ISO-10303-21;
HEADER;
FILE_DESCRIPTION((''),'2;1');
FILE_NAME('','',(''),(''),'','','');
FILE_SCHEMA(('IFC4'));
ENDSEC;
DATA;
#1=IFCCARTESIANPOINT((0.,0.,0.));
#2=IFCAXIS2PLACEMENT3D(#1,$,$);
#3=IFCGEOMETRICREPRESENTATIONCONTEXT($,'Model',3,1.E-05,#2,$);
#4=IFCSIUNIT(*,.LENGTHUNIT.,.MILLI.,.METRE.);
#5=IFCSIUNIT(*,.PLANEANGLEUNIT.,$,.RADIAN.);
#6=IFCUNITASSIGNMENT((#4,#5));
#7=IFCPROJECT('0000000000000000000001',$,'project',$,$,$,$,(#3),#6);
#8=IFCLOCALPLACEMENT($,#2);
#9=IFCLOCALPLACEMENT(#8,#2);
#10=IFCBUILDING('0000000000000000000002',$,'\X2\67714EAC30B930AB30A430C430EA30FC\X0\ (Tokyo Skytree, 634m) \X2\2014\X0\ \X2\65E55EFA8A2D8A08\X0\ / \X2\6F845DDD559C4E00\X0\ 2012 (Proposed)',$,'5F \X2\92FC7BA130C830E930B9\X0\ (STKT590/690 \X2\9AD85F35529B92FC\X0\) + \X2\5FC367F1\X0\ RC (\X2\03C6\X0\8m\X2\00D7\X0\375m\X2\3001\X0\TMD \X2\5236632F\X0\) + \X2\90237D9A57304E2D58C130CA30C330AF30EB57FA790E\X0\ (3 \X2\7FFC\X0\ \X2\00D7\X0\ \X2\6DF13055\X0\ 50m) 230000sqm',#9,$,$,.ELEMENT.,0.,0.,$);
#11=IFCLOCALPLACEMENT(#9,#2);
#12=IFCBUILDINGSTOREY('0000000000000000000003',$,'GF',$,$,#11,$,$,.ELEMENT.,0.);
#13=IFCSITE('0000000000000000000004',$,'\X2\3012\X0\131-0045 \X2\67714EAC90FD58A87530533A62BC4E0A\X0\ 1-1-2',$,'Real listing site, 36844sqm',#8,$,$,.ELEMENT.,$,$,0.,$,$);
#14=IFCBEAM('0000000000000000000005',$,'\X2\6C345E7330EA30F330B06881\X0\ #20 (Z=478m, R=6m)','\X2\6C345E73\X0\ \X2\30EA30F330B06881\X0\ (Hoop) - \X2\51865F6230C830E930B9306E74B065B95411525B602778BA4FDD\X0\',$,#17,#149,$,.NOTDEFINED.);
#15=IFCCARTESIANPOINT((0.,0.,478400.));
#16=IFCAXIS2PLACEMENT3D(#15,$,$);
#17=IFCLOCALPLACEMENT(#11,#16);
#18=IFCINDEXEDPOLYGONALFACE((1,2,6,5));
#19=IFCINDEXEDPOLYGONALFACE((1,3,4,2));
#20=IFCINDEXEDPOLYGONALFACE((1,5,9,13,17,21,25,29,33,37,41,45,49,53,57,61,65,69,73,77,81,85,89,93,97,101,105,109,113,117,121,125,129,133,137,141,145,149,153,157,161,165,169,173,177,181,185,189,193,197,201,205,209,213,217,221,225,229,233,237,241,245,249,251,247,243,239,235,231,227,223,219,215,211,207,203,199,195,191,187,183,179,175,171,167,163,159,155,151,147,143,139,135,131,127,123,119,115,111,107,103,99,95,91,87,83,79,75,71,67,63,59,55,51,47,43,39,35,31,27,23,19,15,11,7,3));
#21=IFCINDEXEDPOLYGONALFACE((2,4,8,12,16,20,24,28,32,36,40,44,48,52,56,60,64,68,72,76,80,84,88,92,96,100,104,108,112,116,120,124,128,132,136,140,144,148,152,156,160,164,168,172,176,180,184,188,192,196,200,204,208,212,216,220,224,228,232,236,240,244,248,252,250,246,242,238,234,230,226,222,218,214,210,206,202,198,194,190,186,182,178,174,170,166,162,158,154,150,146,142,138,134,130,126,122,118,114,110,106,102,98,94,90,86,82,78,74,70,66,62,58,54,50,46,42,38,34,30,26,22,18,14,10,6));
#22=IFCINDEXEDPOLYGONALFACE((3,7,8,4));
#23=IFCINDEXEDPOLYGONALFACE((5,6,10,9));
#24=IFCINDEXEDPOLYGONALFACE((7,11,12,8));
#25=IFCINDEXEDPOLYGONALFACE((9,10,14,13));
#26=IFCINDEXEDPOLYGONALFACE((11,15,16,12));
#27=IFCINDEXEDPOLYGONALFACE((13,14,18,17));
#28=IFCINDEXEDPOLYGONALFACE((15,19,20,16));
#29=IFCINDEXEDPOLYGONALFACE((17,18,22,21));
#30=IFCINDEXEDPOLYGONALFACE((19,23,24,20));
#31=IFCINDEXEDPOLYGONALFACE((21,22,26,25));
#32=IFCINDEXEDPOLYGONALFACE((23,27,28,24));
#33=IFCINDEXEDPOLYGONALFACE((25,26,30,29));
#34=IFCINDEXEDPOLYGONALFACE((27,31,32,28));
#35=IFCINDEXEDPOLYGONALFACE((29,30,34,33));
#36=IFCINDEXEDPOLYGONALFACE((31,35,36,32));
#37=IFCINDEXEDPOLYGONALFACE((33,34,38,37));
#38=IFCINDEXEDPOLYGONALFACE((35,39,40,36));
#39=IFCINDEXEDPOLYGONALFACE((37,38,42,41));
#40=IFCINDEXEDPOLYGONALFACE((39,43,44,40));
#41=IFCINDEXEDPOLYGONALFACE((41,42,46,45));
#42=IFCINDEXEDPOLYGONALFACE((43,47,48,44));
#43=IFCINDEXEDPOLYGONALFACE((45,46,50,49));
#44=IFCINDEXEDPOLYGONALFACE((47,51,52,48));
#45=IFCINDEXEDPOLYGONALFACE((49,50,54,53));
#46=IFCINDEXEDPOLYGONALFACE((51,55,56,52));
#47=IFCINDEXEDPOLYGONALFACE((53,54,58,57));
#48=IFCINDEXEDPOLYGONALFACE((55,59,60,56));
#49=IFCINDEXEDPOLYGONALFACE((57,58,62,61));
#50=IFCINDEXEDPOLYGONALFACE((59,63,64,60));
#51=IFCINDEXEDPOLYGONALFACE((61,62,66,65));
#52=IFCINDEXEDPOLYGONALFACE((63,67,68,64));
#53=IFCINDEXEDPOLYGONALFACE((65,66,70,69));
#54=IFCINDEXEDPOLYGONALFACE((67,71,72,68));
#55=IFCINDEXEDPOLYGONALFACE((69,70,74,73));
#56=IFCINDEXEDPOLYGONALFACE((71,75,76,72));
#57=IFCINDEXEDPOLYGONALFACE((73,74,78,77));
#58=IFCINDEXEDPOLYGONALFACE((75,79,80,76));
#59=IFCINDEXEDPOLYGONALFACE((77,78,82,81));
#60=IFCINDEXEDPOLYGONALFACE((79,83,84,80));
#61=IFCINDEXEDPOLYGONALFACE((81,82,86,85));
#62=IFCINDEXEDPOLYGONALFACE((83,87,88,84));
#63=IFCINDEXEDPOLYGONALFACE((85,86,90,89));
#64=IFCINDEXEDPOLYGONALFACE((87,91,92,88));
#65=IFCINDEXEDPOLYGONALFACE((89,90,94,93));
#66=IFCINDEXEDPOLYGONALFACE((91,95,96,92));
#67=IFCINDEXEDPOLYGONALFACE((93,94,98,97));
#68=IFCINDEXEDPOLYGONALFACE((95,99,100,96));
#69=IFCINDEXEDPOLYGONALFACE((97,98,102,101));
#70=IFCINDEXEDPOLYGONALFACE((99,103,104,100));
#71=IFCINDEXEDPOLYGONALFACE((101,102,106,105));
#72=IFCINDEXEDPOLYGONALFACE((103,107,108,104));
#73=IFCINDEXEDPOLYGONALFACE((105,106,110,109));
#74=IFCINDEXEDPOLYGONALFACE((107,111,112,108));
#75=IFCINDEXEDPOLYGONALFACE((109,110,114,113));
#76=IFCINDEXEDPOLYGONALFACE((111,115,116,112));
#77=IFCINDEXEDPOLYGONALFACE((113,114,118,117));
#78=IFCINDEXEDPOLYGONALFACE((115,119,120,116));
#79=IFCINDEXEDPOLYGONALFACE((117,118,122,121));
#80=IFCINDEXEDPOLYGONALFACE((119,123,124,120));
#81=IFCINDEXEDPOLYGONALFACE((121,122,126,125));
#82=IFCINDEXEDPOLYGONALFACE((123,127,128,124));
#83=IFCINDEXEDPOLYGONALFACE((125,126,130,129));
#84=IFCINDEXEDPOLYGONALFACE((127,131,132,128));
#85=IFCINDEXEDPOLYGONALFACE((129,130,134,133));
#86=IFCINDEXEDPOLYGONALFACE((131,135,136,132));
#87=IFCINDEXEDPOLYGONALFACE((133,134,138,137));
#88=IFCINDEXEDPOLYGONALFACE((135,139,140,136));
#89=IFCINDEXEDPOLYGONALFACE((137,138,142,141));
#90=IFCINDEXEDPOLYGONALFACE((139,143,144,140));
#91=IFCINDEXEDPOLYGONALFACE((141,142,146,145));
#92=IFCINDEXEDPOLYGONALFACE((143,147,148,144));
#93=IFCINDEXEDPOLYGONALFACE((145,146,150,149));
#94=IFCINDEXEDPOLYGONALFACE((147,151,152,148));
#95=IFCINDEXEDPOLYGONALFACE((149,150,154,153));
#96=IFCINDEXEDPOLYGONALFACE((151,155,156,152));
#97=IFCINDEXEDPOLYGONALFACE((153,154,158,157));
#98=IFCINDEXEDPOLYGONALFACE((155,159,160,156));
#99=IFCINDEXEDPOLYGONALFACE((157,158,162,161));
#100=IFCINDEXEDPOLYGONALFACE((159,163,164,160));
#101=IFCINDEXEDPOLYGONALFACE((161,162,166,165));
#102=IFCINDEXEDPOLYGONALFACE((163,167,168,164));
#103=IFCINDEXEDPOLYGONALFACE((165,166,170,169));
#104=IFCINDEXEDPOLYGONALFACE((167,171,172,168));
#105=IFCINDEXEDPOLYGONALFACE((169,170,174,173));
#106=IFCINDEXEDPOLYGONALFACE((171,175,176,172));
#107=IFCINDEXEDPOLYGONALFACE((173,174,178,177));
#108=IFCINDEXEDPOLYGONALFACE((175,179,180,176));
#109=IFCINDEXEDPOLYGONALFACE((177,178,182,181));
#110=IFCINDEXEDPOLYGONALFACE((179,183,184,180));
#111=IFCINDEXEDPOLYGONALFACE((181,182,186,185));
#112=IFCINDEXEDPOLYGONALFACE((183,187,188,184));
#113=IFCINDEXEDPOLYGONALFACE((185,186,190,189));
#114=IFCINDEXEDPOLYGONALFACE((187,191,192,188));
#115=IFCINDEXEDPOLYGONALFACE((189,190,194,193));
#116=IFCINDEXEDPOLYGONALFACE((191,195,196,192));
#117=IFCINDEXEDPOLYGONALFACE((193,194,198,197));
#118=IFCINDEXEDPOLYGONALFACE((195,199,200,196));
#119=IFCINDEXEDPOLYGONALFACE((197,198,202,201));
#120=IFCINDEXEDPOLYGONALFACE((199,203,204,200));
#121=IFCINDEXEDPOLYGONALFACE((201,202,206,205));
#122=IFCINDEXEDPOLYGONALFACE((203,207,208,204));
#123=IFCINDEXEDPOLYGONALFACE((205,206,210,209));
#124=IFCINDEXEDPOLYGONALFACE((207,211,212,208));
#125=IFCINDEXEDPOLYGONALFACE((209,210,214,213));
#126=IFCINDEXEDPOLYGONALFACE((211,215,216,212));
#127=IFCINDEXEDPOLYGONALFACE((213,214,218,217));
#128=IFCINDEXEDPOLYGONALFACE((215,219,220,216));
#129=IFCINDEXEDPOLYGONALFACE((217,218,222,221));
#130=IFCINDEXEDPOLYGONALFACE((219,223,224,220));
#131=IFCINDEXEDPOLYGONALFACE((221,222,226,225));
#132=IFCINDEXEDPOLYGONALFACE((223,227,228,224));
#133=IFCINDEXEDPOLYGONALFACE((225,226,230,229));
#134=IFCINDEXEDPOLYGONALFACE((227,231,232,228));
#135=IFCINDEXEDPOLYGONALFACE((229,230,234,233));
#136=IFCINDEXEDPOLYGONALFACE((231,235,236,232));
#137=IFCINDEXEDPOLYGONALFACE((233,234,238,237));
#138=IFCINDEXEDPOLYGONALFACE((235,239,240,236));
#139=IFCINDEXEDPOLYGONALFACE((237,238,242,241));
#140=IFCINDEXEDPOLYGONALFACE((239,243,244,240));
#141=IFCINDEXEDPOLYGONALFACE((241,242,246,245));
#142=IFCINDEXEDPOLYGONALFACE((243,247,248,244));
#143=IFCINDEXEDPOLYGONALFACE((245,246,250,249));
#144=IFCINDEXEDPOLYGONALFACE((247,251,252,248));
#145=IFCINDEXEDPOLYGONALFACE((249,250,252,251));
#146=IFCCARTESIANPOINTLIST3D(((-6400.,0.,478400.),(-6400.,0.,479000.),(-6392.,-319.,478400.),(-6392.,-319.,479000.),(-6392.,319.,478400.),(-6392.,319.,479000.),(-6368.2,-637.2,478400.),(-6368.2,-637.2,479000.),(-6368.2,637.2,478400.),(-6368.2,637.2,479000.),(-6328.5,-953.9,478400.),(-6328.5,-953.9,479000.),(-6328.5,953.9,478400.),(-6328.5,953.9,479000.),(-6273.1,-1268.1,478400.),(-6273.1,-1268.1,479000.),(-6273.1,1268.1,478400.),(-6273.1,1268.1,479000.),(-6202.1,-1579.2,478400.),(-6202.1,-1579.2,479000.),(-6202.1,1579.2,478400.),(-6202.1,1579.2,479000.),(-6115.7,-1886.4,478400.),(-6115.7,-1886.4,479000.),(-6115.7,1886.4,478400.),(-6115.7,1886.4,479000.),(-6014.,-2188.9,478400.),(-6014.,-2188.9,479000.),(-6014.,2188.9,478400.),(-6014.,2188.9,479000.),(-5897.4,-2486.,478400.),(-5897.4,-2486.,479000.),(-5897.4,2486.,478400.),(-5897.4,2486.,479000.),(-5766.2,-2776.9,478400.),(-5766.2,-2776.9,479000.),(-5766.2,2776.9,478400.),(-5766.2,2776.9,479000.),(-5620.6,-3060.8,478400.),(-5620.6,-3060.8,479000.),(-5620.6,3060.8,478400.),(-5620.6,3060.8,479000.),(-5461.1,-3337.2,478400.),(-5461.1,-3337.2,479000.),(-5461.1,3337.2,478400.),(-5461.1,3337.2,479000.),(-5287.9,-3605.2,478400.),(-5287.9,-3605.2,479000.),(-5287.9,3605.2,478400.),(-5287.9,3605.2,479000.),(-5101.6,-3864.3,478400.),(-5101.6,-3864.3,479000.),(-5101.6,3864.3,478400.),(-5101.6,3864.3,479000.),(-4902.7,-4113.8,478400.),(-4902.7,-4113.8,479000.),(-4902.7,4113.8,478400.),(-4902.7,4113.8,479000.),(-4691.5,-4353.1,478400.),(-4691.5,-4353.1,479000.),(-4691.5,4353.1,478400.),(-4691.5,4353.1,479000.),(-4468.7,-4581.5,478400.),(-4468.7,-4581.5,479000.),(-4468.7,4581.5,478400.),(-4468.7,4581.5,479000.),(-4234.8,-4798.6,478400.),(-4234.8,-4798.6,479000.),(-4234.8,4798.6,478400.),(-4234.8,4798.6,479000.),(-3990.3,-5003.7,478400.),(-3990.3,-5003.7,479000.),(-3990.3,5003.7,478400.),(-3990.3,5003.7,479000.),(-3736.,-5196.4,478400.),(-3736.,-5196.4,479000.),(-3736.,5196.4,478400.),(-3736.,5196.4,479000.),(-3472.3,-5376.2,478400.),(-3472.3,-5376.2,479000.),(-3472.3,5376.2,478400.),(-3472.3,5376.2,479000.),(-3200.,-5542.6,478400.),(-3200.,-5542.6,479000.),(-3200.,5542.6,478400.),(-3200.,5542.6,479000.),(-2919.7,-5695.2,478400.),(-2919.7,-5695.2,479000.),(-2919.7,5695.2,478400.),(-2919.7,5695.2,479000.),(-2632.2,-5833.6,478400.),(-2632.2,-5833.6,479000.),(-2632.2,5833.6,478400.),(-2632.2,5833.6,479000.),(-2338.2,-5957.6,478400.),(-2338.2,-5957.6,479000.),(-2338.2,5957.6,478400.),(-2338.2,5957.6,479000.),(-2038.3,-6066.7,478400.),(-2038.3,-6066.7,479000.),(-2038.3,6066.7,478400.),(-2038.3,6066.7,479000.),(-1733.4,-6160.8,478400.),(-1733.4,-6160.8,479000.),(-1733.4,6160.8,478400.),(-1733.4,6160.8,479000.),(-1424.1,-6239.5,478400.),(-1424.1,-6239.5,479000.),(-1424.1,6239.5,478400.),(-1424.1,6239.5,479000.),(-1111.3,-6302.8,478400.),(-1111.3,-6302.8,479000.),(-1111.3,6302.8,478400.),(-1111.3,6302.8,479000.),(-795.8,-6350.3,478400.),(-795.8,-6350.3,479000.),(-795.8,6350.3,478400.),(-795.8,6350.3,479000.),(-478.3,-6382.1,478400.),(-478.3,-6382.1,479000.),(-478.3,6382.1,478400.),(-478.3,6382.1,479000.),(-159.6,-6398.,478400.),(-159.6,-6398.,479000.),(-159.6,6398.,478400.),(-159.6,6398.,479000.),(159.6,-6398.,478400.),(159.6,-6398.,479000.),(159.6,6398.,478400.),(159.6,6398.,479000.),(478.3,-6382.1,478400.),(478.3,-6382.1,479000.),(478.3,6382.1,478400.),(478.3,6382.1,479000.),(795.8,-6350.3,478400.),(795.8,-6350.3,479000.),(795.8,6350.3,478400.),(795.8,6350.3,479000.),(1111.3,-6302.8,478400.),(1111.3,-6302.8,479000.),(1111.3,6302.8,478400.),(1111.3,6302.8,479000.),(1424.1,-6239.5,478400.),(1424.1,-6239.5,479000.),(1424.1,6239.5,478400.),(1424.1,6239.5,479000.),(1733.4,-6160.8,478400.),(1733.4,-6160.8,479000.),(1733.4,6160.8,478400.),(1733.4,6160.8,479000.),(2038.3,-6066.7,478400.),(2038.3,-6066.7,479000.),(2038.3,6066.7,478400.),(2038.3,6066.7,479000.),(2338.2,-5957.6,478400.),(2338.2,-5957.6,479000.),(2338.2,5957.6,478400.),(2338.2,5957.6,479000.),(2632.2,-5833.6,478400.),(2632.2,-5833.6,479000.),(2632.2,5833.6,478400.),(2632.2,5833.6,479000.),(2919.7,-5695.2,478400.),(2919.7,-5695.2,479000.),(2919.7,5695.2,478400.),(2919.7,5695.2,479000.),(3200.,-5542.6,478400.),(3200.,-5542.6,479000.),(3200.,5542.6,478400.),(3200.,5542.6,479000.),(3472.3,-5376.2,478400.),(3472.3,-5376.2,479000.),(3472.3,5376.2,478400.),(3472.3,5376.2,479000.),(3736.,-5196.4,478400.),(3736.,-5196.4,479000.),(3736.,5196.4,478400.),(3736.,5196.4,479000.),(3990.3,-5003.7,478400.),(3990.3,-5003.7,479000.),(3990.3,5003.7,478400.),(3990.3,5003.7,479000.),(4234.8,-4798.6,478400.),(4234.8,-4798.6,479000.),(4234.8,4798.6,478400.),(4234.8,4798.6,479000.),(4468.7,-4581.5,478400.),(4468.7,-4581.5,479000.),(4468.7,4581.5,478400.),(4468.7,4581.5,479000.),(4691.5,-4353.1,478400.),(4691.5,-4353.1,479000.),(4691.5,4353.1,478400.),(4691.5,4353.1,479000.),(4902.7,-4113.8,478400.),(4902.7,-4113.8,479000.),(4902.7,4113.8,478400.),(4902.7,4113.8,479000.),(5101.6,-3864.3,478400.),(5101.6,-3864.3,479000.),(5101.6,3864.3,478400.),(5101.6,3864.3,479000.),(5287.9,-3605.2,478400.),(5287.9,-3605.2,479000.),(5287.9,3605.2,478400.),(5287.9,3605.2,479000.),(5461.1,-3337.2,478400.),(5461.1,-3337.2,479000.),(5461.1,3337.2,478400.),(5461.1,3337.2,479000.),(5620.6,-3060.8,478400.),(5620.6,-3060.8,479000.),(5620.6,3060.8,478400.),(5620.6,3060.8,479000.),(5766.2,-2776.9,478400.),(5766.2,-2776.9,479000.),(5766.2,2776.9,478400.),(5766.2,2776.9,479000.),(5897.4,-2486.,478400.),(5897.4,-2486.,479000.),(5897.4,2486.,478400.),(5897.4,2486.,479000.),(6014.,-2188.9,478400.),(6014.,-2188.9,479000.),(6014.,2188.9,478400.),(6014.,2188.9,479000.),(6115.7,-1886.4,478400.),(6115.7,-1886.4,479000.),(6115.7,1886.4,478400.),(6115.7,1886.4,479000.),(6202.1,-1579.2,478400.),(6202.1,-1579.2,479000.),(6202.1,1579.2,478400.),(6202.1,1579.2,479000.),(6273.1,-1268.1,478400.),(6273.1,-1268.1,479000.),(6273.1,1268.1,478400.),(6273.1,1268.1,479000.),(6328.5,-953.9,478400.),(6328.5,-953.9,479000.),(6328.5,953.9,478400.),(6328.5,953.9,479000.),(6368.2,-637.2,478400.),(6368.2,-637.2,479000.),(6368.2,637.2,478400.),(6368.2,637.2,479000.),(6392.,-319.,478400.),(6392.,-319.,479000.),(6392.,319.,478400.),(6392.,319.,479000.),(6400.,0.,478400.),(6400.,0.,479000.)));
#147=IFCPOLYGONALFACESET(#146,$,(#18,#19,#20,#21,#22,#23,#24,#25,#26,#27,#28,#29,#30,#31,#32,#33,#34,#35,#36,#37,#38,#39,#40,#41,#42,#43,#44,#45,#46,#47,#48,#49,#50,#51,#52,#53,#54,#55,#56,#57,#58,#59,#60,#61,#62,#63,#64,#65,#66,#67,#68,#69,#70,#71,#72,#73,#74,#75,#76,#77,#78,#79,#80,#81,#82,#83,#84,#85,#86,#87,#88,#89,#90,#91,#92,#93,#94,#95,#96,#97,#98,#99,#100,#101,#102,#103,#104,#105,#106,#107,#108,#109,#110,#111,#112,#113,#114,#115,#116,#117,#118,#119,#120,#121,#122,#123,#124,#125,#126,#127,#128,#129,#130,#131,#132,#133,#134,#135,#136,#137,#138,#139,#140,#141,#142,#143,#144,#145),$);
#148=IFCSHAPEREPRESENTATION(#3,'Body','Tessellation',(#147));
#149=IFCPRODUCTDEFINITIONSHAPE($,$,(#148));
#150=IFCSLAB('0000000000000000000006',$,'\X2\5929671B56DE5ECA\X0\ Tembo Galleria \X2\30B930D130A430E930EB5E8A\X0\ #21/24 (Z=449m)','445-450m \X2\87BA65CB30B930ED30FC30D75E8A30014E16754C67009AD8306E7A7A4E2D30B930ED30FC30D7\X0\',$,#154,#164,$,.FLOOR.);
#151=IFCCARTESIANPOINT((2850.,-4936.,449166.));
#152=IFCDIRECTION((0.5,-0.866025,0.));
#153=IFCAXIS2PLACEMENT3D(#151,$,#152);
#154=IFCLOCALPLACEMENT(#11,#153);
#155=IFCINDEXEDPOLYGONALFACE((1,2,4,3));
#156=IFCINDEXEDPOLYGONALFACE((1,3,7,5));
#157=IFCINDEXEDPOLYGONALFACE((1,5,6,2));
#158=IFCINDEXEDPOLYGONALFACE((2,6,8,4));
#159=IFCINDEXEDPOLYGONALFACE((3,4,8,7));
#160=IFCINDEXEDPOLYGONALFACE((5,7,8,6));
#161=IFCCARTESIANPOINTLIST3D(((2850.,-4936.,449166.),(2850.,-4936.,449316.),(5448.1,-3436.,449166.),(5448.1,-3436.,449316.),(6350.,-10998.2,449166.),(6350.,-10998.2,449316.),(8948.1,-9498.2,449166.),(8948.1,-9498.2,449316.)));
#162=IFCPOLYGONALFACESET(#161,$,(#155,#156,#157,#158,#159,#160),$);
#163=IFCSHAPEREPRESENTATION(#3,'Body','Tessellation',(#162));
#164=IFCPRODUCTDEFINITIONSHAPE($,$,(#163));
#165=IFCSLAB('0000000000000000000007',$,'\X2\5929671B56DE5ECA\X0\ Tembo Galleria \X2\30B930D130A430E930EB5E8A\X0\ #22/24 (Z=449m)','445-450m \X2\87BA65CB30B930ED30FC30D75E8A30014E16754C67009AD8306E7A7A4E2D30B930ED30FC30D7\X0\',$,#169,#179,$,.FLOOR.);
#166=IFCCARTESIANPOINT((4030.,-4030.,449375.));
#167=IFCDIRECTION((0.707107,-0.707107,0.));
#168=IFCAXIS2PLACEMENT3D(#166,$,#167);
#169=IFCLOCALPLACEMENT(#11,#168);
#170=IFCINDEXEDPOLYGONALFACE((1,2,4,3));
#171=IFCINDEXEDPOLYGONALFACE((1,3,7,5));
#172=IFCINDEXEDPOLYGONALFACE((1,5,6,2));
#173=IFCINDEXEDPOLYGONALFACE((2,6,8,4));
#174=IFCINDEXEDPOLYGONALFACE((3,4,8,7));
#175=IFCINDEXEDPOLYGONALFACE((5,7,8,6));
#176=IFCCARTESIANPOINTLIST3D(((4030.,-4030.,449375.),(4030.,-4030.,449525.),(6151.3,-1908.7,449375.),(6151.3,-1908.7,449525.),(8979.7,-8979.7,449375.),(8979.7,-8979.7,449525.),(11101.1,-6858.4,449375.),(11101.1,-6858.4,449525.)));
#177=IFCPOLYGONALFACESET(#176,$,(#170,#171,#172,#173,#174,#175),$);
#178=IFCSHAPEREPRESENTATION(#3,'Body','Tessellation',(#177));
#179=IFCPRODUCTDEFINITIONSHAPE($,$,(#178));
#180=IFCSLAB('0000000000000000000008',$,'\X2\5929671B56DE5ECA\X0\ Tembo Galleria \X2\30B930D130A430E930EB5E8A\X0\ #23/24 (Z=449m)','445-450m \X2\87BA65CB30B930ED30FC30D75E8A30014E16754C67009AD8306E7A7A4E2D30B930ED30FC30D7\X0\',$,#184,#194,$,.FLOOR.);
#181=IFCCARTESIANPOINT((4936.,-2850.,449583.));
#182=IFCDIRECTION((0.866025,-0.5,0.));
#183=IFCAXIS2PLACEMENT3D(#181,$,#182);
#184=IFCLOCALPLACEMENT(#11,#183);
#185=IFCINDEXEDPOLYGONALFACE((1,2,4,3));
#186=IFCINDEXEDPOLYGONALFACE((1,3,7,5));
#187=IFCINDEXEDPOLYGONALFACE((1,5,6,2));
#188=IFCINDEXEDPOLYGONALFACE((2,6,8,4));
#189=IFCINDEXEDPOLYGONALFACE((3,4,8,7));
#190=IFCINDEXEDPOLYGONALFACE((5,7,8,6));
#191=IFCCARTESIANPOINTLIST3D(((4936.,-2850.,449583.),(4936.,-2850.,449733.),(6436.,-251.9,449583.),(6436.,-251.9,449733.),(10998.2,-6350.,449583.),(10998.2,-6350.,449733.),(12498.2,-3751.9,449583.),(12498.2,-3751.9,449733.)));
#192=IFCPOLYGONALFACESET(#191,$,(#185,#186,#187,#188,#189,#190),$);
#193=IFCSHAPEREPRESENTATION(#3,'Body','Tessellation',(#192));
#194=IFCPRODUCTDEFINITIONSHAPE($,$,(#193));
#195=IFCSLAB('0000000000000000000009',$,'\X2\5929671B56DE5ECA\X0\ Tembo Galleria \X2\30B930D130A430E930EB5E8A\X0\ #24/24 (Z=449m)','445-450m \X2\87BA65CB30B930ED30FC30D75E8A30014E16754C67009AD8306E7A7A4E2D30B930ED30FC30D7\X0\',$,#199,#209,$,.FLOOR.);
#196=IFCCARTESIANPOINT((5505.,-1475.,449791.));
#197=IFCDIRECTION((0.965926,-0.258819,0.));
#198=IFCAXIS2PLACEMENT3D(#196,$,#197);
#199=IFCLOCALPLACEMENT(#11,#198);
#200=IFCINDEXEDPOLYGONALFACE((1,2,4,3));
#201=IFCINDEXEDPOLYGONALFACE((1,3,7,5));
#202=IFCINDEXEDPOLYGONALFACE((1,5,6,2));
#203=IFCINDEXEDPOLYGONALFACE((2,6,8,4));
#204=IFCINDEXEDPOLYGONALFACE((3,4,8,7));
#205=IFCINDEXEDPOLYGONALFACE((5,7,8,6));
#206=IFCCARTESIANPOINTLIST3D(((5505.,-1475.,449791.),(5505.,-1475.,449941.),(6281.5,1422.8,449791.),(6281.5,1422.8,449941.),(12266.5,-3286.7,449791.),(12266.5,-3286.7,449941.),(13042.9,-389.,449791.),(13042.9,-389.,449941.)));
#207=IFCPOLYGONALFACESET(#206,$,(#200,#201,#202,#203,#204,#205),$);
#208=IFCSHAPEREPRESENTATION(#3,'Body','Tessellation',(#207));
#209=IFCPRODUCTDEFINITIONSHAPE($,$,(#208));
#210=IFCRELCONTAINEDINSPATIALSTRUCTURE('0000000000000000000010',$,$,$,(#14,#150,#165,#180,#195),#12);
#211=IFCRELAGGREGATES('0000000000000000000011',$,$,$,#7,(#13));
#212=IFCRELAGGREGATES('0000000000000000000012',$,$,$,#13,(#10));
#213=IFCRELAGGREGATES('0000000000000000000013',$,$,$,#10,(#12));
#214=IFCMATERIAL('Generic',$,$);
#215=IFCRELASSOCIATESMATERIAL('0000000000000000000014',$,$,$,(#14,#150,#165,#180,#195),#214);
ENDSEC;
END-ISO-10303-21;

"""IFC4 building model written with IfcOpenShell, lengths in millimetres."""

from ifc_helpers import new_model, si_unit, frame, frame_2d, origin, origin_2d, place, context, project, spatial, rectangle, circle, extrude, material, element, save


model = new_model("IFC4")

# Units and contexts
model_context = context("Model", 3, precision=1e-05, world=origin())
ifc_project = project(units=[si_unit("LENGTHUNIT", "METRE", prefix="MILLI"), si_unit("PLANEANGLEUNIT", "RADIAN")], contexts=[model_context])

# Site, building, storey
site_placement = place(None, origin())
site = spatial("IfcSite", under=ifc_project, at=site_placement, Name="〒131-0045 東京都墨田区押上 1-1-2", ObjectType="Real listing site, 36844sqm", CompositionType="ELEMENT", RefElevation=0.0)
building_placement = place(site_placement, origin())
building = spatial("IfcBuilding", under=site, at=building_placement, Name="東京スカイツリー (Tokyo Skytree, 634m) — 日建設計 / 澄川喜一 2012 (Proposed)", ObjectType="5F 鋼管トラス (STKT590/690 高張力鋼) + 心柱 RC (φ8m×375m、TMD 制振) + 連続地中壁ナックル基礎 (3 翼 × 深さ 50m) 230000sqm", CompositionType="ELEMENT", ElevationOfRefHeight=0.0, ElevationOfTerrain=0.0)
storey_placement = place(building_placement, origin())
storey = spatial("IfcBuildingStorey", under=building, at=storey_placement, Name="GF", CompositionType="ELEMENT", Elevation=0.0)

# Shared definitions
ifc_material = material(Name="Generic")

# Beam
beam_1_placement = place(storey_placement, frame((0.0, 0.0, 478400.0)))
element("IfcBeam", 1, at=beam_1_placement, inside=storey, material=ifc_material, Name="水平リング梁 #20 (Z=478m, R=6m)", Description="水平 リング梁 (Hoop) - 円形トラスの環方向剛性確保", PredefinedType="NOTDEFINED", context=model_context, shape_type="SweptSolid", body=[
    extrude(circle(Radius=6400.0, at=origin_2d()), frame((0.0, 0.0, 478400.0)), (0.0, 0.0, 1.0), 600.0),
])

# Slabs
slab_1_placement = place(storey_placement, frame((2850.0, -4936.0, 449166.0), x_axis=(0.5, -0.866025, 0.0)))
element("IfcSlab", 2, at=slab_1_placement, inside=storey, material=ifc_material, Name="天望回廊 Tembo Galleria スパイラル床 #21/24 (Z=449m)", Description="445-450m 螺旋スロープ床、世界最高の空中スロープ", PredefinedType="FLOOR", context=model_context, shape_type="SweptSolid", body=[
    extrude(rectangle(XDim=7000.0, YDim=3000.0, at=frame_2d((3500.0, 1500.0))), frame((2850.0, -4936.0, 449166.0), x_axis=(0.5, -0.866025, 0.0)), (0.0, 0.0, 1.0), 150.0),
])
slab_2_placement = place(storey_placement, frame((4030.0, -4030.0, 449375.0), x_axis=(0.707107, -0.707107, 0.0)))
element("IfcSlab", 3, at=slab_2_placement, inside=storey, material=ifc_material, Name="天望回廊 Tembo Galleria スパイラル床 #22/24 (Z=449m)", Description="445-450m 螺旋スロープ床、世界最高の空中スロープ", PredefinedType="FLOOR", context=model_context, shape_type="SweptSolid", body=[
    extrude(rectangle(XDim=7000.0, YDim=3000.0, at=frame_2d((3500.0, 1500.0))), frame((4030.0, -4030.0, 449375.0), x_axis=(0.707107, -0.707107, 0.0)), (0.0, 0.0, 1.0), 150.0),
])
slab_3_placement = place(storey_placement, frame((4936.0, -2850.0, 449583.0), x_axis=(0.866025, -0.5, 0.0)))
element("IfcSlab", 4, at=slab_3_placement, inside=storey, material=ifc_material, Name="天望回廊 Tembo Galleria スパイラル床 #23/24 (Z=449m)", Description="445-450m 螺旋スロープ床、世界最高の空中スロープ", PredefinedType="FLOOR", context=model_context, shape_type="SweptSolid", body=[
    extrude(rectangle(XDim=7000.0, YDim=3000.0, at=frame_2d((3500.0, 1500.0))), frame((4936.0, -2850.0, 449583.0), x_axis=(0.866025, -0.5, 0.0)), (0.0, 0.0, 1.0), 150.0),
])
slab_4_placement = place(storey_placement, frame((5505.0, -1475.0, 449791.0), x_axis=(0.965926, -0.258819, 0.0)))
element("IfcSlab", 5, at=slab_4_placement, inside=storey, material=ifc_material, Name="天望回廊 Tembo Galleria スパイラル床 #24/24 (Z=449m)", Description="445-450m 螺旋スロープ床、世界最高の空中スロープ", PredefinedType="FLOOR", context=model_context, shape_type="SweptSolid", body=[
    extrude(rectangle(XDim=7000.0, YDim=3000.0, at=frame_2d((3500.0, 1500.0))), frame((5505.0, -1475.0, 449791.0), x_axis=(0.965926, -0.258819, 0.0)), (0.0, 0.0, 1.0), 150.0),
])

save(model, "model.ifc")
